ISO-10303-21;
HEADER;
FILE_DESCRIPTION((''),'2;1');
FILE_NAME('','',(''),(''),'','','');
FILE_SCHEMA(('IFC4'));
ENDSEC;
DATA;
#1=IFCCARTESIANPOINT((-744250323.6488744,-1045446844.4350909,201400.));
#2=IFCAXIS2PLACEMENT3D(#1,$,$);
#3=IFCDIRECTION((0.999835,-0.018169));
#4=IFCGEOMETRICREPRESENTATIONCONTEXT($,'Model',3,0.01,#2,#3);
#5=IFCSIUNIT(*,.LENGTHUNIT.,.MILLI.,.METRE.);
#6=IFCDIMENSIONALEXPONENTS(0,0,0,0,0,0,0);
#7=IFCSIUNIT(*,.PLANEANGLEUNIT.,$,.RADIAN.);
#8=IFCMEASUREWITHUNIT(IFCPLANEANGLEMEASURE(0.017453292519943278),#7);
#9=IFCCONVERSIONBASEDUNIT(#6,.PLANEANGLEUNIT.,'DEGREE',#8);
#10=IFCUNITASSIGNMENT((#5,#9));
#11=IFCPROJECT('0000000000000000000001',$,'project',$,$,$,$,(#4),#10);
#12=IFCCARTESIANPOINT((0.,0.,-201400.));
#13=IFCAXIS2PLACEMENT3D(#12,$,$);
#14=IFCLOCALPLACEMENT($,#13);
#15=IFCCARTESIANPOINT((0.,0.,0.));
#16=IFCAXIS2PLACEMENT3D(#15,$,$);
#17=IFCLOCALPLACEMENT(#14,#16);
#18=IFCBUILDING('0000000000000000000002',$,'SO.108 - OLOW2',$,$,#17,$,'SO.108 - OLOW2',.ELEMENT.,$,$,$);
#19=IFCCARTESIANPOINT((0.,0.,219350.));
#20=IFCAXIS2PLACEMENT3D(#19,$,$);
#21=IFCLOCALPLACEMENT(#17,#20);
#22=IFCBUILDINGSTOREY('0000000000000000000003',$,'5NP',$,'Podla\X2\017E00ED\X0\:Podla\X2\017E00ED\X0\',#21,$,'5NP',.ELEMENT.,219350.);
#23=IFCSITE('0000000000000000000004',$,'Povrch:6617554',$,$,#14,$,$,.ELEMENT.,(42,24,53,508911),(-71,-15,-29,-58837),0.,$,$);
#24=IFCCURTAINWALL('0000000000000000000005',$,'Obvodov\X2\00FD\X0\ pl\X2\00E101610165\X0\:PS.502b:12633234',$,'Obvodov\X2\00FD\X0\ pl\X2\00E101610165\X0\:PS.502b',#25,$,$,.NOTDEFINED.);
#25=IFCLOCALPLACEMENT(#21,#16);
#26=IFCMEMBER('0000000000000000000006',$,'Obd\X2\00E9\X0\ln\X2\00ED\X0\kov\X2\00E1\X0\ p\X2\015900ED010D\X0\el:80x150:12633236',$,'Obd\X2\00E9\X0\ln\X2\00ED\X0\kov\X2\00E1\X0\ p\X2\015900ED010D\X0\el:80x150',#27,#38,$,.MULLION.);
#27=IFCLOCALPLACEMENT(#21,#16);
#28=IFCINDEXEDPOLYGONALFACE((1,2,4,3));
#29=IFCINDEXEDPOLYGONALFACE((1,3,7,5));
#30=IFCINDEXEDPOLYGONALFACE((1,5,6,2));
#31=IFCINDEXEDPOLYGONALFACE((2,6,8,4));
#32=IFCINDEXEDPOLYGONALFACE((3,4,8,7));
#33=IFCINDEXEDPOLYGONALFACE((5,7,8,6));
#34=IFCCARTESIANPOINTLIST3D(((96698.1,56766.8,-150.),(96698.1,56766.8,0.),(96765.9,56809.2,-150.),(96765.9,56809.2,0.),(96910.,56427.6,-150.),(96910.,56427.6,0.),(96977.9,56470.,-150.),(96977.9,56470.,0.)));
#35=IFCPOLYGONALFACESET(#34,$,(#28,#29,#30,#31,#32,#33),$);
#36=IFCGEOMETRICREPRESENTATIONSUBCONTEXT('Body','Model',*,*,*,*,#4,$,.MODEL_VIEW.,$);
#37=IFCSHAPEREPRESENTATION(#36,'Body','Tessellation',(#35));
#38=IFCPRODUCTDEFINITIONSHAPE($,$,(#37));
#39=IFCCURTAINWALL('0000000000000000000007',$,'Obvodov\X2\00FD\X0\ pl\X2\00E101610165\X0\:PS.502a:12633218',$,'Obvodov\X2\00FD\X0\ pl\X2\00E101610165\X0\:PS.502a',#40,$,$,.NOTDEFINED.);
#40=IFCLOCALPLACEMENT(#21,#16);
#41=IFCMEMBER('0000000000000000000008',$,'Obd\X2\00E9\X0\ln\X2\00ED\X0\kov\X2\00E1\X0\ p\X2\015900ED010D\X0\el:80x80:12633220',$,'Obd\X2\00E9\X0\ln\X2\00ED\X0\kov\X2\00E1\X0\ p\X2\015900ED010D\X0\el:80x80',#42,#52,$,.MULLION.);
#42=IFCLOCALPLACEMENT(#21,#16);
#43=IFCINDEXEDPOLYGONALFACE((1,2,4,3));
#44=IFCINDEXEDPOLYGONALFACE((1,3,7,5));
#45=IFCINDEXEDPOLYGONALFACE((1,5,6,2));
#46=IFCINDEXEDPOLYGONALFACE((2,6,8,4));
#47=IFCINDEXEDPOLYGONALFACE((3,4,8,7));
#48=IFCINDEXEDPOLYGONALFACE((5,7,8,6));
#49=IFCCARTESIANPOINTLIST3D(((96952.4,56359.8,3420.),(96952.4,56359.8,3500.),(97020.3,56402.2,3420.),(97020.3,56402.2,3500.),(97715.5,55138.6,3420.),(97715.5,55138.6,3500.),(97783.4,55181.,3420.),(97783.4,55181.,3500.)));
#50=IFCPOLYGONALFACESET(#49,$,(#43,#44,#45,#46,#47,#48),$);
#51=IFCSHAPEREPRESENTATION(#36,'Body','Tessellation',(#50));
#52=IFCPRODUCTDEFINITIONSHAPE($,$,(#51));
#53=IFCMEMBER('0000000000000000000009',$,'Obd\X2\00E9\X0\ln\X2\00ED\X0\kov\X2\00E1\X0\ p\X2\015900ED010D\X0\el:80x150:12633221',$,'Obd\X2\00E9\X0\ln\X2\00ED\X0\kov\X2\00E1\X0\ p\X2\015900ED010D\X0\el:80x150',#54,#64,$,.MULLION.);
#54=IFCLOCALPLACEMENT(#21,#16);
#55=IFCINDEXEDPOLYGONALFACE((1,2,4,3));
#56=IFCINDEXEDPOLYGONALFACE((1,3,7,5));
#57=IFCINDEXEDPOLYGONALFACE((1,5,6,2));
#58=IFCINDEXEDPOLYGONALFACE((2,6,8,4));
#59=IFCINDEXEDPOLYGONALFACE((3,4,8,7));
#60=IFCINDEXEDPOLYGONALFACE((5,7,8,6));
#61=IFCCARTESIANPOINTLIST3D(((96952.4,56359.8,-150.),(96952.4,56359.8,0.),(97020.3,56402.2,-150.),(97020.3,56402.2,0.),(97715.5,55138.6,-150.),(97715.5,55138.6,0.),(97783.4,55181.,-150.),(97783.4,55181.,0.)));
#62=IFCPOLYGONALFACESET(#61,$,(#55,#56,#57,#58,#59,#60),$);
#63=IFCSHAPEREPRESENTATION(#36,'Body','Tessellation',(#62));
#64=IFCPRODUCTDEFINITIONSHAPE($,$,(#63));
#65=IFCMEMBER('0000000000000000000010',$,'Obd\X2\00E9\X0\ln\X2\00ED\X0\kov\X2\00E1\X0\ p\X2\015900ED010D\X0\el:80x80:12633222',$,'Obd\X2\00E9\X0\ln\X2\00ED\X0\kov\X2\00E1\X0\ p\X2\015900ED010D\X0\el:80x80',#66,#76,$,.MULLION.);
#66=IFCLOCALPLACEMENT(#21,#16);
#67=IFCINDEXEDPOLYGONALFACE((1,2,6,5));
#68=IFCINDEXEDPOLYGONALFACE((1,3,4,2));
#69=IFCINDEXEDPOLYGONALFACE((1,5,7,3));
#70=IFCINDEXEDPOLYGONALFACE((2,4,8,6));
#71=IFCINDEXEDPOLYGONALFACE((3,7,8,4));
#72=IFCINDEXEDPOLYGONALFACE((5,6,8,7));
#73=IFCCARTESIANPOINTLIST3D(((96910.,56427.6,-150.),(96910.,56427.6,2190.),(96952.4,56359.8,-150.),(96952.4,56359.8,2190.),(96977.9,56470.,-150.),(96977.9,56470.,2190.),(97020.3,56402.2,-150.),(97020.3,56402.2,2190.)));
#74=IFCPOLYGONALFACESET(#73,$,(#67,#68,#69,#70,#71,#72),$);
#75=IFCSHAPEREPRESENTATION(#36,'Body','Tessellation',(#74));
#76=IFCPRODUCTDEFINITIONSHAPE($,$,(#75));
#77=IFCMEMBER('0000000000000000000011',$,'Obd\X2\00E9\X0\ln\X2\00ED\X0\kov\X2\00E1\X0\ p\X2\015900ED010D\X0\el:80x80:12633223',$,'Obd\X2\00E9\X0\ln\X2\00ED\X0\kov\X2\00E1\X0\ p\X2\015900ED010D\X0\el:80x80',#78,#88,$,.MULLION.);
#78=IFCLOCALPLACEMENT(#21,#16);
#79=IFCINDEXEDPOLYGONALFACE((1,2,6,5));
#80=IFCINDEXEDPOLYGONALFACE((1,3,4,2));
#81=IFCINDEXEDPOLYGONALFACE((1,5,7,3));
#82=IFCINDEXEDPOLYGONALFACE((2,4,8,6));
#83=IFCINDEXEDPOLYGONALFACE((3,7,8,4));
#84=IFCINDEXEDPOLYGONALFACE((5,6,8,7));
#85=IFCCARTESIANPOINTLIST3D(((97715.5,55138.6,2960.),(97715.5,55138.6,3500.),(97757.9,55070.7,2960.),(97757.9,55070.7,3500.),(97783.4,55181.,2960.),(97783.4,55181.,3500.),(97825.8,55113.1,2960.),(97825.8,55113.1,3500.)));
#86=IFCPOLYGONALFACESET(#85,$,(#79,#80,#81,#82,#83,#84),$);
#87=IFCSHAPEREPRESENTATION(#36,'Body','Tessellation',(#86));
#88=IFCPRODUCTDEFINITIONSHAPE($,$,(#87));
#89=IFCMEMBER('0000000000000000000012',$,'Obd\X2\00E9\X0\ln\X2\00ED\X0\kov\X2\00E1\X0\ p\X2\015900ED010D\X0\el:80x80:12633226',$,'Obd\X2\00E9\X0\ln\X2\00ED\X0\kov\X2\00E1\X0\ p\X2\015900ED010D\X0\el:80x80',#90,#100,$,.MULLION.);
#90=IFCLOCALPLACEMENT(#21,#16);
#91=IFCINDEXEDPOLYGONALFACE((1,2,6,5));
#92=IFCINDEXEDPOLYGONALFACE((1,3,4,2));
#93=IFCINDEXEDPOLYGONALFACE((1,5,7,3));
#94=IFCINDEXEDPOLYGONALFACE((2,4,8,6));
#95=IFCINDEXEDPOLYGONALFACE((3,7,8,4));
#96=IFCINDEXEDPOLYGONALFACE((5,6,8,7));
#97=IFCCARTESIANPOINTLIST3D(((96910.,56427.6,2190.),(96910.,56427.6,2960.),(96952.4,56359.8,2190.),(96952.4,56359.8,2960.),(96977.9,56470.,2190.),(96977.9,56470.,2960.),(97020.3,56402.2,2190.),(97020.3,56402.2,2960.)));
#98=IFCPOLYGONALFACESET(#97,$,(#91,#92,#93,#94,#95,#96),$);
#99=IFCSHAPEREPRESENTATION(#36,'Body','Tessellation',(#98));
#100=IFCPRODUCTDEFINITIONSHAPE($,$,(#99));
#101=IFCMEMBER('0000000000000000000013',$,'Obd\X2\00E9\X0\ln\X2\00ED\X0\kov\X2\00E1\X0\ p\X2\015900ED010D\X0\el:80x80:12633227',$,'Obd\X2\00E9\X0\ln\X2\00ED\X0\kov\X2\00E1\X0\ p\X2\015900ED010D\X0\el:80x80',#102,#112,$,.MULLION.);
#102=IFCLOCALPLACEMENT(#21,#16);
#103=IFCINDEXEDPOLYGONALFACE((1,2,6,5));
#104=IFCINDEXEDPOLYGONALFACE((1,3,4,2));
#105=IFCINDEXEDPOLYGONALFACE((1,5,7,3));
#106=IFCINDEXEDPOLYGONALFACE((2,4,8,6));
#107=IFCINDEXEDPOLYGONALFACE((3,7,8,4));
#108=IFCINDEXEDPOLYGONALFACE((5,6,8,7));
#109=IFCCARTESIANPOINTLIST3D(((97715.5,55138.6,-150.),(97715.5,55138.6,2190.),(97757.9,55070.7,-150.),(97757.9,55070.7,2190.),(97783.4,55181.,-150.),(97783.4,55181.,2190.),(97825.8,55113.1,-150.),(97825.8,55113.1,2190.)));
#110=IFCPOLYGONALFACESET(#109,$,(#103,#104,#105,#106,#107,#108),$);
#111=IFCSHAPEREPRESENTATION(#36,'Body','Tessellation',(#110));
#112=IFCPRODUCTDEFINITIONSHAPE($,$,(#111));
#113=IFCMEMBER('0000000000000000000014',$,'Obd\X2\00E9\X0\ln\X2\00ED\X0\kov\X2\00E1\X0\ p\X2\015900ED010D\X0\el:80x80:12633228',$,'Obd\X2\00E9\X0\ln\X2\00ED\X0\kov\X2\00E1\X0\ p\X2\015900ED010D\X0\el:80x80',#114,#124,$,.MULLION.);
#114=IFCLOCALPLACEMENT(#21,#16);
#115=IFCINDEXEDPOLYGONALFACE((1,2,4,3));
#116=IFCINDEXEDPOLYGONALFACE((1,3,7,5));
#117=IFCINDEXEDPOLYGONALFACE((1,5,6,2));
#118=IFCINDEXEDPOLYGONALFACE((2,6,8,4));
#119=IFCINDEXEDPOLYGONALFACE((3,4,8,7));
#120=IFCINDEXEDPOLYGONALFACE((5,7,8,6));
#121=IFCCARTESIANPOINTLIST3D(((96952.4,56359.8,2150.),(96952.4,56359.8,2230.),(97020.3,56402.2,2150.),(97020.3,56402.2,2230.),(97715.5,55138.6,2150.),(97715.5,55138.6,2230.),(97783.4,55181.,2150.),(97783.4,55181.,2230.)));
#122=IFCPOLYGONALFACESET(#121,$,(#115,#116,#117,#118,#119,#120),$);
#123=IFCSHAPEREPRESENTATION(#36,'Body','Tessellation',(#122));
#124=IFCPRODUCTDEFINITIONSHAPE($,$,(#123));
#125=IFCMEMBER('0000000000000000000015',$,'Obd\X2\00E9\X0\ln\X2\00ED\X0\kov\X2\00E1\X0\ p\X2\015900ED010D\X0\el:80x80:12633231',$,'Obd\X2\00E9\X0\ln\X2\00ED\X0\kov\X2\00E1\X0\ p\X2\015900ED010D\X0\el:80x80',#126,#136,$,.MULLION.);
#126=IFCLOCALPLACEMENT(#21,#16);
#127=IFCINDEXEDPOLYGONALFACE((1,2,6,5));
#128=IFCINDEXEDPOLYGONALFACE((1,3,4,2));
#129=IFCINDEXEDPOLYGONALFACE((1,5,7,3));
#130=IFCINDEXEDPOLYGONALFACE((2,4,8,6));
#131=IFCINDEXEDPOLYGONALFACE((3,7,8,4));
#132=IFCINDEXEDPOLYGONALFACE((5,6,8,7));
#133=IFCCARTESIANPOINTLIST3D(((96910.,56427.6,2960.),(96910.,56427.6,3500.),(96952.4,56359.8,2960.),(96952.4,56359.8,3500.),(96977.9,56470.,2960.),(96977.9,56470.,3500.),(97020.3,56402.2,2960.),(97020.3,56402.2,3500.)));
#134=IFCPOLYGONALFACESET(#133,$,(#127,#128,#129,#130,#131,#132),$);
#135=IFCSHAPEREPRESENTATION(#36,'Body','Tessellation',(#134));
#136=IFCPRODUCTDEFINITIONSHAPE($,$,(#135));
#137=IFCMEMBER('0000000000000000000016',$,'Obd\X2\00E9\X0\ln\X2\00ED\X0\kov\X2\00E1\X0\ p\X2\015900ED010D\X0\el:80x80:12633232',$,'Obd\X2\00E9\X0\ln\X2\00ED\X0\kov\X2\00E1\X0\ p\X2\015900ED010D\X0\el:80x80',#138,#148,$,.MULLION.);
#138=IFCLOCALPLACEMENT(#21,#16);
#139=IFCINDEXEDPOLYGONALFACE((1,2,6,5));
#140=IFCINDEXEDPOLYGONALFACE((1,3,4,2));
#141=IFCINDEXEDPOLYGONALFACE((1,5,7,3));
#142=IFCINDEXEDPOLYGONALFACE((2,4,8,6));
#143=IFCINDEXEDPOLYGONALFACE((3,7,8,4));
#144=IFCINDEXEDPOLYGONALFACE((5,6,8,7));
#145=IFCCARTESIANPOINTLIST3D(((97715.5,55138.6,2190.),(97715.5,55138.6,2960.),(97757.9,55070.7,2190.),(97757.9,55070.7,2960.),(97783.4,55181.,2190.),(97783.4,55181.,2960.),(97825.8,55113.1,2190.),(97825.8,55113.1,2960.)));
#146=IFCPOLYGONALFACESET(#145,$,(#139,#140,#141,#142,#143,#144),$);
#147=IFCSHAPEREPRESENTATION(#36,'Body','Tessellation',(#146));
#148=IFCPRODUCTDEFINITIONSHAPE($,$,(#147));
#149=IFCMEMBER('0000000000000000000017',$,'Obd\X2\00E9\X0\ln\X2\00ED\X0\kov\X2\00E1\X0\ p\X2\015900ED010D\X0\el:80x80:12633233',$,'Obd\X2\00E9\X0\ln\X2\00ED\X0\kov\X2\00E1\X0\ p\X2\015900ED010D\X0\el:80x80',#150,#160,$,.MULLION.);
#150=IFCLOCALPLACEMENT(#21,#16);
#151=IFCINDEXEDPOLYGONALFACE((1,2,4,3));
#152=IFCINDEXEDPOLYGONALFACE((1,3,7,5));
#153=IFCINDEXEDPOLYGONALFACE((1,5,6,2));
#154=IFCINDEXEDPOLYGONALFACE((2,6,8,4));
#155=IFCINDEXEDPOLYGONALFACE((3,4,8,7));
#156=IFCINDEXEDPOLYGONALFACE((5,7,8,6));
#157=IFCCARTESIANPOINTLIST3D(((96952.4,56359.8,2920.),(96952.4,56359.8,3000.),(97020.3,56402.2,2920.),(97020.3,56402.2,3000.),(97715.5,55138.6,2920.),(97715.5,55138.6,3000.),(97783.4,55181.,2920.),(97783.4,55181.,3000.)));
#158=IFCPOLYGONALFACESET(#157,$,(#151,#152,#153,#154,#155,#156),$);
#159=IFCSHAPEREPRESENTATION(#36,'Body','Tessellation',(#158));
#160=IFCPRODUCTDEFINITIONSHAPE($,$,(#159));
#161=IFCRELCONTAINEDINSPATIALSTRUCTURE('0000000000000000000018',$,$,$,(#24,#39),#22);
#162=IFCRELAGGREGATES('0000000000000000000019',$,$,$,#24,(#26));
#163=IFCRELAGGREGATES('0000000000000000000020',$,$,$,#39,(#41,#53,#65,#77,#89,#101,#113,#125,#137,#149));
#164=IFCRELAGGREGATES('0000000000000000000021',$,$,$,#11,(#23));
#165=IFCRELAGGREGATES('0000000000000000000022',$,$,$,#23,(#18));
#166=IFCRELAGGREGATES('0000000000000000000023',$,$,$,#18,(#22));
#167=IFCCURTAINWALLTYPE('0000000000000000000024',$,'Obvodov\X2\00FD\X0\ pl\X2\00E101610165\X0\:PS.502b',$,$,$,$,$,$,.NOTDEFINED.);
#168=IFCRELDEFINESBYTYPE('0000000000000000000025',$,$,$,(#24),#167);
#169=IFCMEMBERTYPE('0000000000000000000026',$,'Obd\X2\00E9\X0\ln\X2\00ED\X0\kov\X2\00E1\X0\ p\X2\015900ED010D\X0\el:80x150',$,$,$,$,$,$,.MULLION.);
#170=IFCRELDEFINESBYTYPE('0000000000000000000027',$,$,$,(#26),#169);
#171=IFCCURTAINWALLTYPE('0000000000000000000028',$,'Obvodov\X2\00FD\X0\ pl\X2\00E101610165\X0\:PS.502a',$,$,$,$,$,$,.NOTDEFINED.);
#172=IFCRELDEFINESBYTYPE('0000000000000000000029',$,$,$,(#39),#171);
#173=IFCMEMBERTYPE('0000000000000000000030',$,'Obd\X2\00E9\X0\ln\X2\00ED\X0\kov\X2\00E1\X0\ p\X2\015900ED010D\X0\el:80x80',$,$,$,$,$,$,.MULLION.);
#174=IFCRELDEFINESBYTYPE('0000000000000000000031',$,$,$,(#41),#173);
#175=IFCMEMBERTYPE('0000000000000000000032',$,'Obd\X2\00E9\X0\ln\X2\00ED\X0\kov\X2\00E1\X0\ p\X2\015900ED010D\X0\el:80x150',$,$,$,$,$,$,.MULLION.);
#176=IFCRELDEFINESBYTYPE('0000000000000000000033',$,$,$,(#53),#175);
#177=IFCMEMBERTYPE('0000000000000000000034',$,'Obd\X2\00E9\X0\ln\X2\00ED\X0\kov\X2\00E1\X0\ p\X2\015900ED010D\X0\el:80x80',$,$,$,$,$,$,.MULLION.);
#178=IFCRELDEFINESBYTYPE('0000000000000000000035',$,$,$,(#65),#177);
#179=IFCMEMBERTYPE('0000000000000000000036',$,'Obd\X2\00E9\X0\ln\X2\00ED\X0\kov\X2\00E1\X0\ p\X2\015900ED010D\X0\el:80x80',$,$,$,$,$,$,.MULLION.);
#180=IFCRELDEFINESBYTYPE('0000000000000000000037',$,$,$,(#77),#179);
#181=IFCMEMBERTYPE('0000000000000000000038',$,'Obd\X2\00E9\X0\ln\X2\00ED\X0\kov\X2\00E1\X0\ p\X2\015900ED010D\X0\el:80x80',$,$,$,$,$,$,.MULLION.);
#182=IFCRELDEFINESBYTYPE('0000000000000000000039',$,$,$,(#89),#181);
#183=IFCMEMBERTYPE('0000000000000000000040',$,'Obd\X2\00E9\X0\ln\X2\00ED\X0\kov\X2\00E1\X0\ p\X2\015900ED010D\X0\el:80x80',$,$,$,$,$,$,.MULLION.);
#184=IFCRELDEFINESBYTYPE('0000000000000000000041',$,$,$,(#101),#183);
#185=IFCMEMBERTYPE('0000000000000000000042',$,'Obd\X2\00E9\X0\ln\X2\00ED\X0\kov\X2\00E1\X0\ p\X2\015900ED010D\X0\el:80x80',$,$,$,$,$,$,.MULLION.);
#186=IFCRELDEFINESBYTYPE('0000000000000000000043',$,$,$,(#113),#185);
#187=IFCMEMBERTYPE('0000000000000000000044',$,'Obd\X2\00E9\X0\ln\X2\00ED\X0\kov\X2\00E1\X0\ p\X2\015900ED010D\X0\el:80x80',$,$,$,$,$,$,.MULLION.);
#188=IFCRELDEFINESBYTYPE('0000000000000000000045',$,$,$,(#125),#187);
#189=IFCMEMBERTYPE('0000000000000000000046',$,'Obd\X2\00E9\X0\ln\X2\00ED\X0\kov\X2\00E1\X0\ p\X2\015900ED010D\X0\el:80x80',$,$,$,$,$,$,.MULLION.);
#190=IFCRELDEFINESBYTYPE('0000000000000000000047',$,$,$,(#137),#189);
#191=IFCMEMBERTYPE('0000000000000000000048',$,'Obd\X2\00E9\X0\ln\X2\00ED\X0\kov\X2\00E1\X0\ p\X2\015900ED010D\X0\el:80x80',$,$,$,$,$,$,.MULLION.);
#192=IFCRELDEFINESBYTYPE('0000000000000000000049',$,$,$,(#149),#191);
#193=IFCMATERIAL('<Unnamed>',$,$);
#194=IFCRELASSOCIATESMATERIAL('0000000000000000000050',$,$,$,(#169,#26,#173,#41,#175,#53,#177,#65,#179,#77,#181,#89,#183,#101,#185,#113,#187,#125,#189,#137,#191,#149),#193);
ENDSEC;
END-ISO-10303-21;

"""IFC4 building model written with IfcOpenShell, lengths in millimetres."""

from ifc_helpers import new_model, entity, si_unit, converted_unit, direction, frame, origin, place, context, subcontext, project, spatial, indexed_curve, outline, extrude, source, transform, mapped, material, type_object, type_shapes, element, aggregate, save


model = new_model("IFC4")

# Units and contexts
model_context = context("Model", 3, precision=0.01, world=frame((-744250323.6488744, -1045446844.4350909, 201400.0)), true_north=direction((0.999835, -0.018169)))
body_context = subcontext(model_context, "Body", "Model", "MODEL_VIEW")
ifc_project = project(units=[si_unit("LENGTHUNIT", "METRE", prefix="MILLI"), converted_unit("PLANEANGLEUNIT", "DEGREE", entity("IfcPlaneAngleMeasure", 0.017453292519943278), si_unit("PLANEANGLEUNIT", "RADIAN"), dimensions=[0, 0, 0, 0, 0, 0, 0])], contexts=[model_context])

# Site, building, storey
site_placement = place(None, frame((0.0, 0.0, -201400.0)))
site = spatial("IfcSite", under=ifc_project, at=site_placement, Name="Povrch:6617554", CompositionType="ELEMENT", RefLatitude=(42, 24, 53, 508911), RefLongitude=(-71, -15, -29, -58837), RefElevation=0.0)
building_placement = place(site_placement, origin())
building = spatial("IfcBuilding", under=site, at=building_placement, Name="SO.108 - OLOW2", LongName="SO.108 - OLOW2", CompositionType="ELEMENT")
storey_placement = place(building_placement, frame((0.0, 0.0, 219350.0)))
storey = spatial("IfcBuildingStorey", under=building, at=storey_placement, Name="5NP", ObjectType="Podlaží:Podlaží", LongName="5NP", CompositionType="ELEMENT", Elevation=219350.0)

# Shared definitions
ifc_material_1 = material(Name="<Unnamed>")

# Curtain wall, member
curtain_wall_type_1 = type_object("IfcCurtainWallType", Name="Obvodový plášť:PS.502b", PredefinedType="NOTDEFINED")
curtain_wall_1_placement = place(storey_placement, frame((0.0, 0.0, -219350.0)))
curtain_wall_1 = element("IfcCurtainWall", 1, at=curtain_wall_1_placement, inside=storey, type_object=curtain_wall_type_1, Name="Obvodový plášť:PS.502b:12633234", ObjectType="Obvodový plášť:PS.502b", PredefinedType="NOTDEFINED")
member_type_1 = type_object("IfcMemberType", Name="Obdélníková příčel:80x150", PredefinedType="MULLION", material=ifc_material_1)
shared_shape_1 = source(origin(), body_context, "Body", "SweptSolid", [
    extrude(outline(indexed_curve([(-75.0, -40.0), (75.0, -40.0), (75.0, 40.0), (-75.0, 40.0), (-75.0, -40.0)], self_intersect=False)), frame((-75.0, 0.0, -400.0), z_axis=(0.0, 0.0, 1.0), x_axis=(-1.0, 0.0, 0.0)), (0.0, 0.0, 1.0), 400.0),
])
type_shapes(member_type_1, [shared_shape_1])
member_1_placement = place(curtain_wall_1_placement, frame((96732.0, 56788.0, 219200.0), z_axis=(-0.529919, 0.848048, 0.0), x_axis=(0.0, 0.0, -1.0)))
member_1 = element("IfcMember", 2, at=member_1_placement, type_object=member_type_1, material=ifc_material_1, Name="Obdélníková příčel:80x150:12633236", ObjectType="Obdélníková příčel:80x150", PredefinedType="MULLION", context=body_context, shape_type="MappedRepresentation", body=[
    mapped(shared_shape_1, transform((0.0, 0.0, 0.0), scale=1.0)),
])

# Curtain wall, members
curtain_wall_type_2 = type_object("IfcCurtainWallType", Name="Obvodový plášť:PS.502a", PredefinedType="NOTDEFINED")
curtain_wall_2_placement = place(storey_placement, frame((0.0, 0.0, -219350.0)))
curtain_wall_2 = element("IfcCurtainWall", 3, at=curtain_wall_2_placement, inside=storey, type_object=curtain_wall_type_2, Name="Obvodový plášť:PS.502a:12633218", ObjectType="Obvodový plášť:PS.502a", PredefinedType="NOTDEFINED")
member_type_2 = type_object("IfcMemberType", Name="Obdélníková příčel:80x80", PredefinedType="MULLION", material=ifc_material_1)
shared_shape_2 = source(origin(), body_context, "Body", "SweptSolid", [
    extrude(outline(indexed_curve([(-40.0, -40.0), (40.0, -40.0), (40.0, 40.0), (-40.0, 40.0), (-40.0, -40.0)], self_intersect=False)), frame((-40.0, 0.0, -1440.0), z_axis=(0.0, 0.0, 1.0), x_axis=(-1.0, 0.0, 0.0)), (0.0, 0.0, 1.0), 1440.0),
])
type_shapes(member_type_2, [shared_shape_2])
member_2_placement = place(curtain_wall_2_placement, frame((96986.4, 56381.0, 222850.0), z_axis=(-0.529919, 0.848048, 0.0), x_axis=(0.0, 0.0, 1.0)))
member_2 = element("IfcMember", 4, at=member_2_placement, type_object=member_type_2, material=ifc_material_1, Name="Obdélníková příčel:80x80:12633220", ObjectType="Obdélníková příčel:80x80", PredefinedType="MULLION", context=body_context, shape_type="MappedRepresentation", body=[
    mapped(shared_shape_2, transform((0.0, 0.0, 0.0), scale=1.0)),
])
member_type_3 = type_object("IfcMemberType", Name="Obdélníková příčel:80x150", PredefinedType="MULLION", material=ifc_material_1)
shared_shape_3 = source(origin(), body_context, "Body", "SweptSolid", [
    extrude(outline(indexed_curve([(-75.0, -40.0), (75.0, -40.0), (75.0, 40.0), (-75.0, 40.0), (-75.0, -40.0)], self_intersect=False)), frame((-75.0, 0.0, -1440.0), z_axis=(0.0, 0.0, 1.0), x_axis=(-1.0, 0.0, 0.0)), (0.0, 0.0, 1.0), 1440.0),
])
type_shapes(member_type_3, [shared_shape_3])
member_3_placement = place(curtain_wall_2_placement, frame((97749.4, 55159.8, 219200.0), z_axis=(0.529919, -0.848048, 0.0), x_axis=(0.0, 0.0, -1.0)))
member_3 = element("IfcMember", 5, at=member_3_placement, type_object=member_type_3, material=ifc_material_1, Name="Obdélníková příčel:80x150:12633221", ObjectType="Obdélníková příčel:80x150", PredefinedType="MULLION", context=body_context, shape_type="MappedRepresentation", body=[
    mapped(shared_shape_3, transform((0.0, 0.0, 0.0), scale=1.0)),
])
member_type_4 = type_object("IfcMemberType", Name="Obdélníková příčel:80x80", PredefinedType="MULLION", material=ifc_material_1)
shared_shape_4 = source(origin(), body_context, "Body", "SweptSolid", [
    extrude(outline(indexed_curve([(-40.0, -40.0), (40.0, -40.0), (40.0, 40.0), (-40.0, 40.0), (-40.0, -40.0)], self_intersect=False)), frame((-40.0, 0.0, -2340.0), z_axis=(0.0, 0.0, 1.0), x_axis=(-1.0, 0.0, 0.0)), (0.0, 0.0, 1.0), 2340.0),
])
type_shapes(member_type_4, [shared_shape_4])
member_4_placement = place(curtain_wall_2_placement, frame((96944.0, 56448.8, 219200.0), z_axis=(0.0, 0.0, -1.0), x_axis=(-0.529919, 0.848048, 0.0)))
member_4 = element("IfcMember", 6, at=member_4_placement, type_object=member_type_4, material=ifc_material_1, Name="Obdélníková příčel:80x80:12633222", ObjectType="Obdélníková příčel:80x80", PredefinedType="MULLION", context=body_context, shape_type="MappedRepresentation", body=[
    mapped(shared_shape_4, transform((0.0, 0.0, 0.0), scale=1.0)),
])
member_type_5 = type_object("IfcMemberType", Name="Obdélníková příčel:80x80", PredefinedType="MULLION", material=ifc_material_1)
shared_shape_5 = source(origin(), body_context, "Body", "SweptSolid", [
    extrude(outline(indexed_curve([(-40.0, -40.0), (40.0, -40.0), (40.0, 40.0), (-40.0, 40.0), (-40.0, -40.0)], self_intersect=False)), frame((-40.0, 0.0, -540.0), z_axis=(0.0, 0.0, 1.0), x_axis=(-1.0, 0.0, 0.0)), (0.0, 0.0, 1.0), 540.0),
])
type_shapes(member_type_5, [shared_shape_5])
member_5_placement = place(curtain_wall_2_placement, frame((97791.8, 55091.9, 222850.0), z_axis=(0.0, 0.0, 1.0), x_axis=(0.529919, -0.848048, 0.0)))
member_5 = element("IfcMember", 7, at=member_5_placement, type_object=member_type_5, material=ifc_material_1, Name="Obdélníková příčel:80x80:12633223", ObjectType="Obdélníková příčel:80x80", PredefinedType="MULLION", context=body_context, shape_type="MappedRepresentation", body=[
    mapped(shared_shape_5, transform((0.0, 0.0, 0.0), scale=1.0)),
])
member_type_6 = type_object("IfcMemberType", Name="Obdélníková příčel:80x80", PredefinedType="MULLION", material=ifc_material_1)
shared_shape_6 = source(origin(), body_context, "Body", "SweptSolid", [
    extrude(outline(indexed_curve([(-40.0, -40.0), (40.0, -40.0), (40.0, 40.0), (-40.0, 40.0), (-40.0, -40.0)], self_intersect=False)), frame((-40.0, 0.0, -770.0), z_axis=(0.0, 0.0, 1.0), x_axis=(-1.0, 0.0, 0.0)), (0.0, 0.0, 1.0), 770.0),
])
type_shapes(member_type_6, [shared_shape_6])
member_6_placement = place(curtain_wall_2_placement, frame((96944.0, 56448.8, 221540.0), z_axis=(0.0, 0.0, -1.0), x_axis=(-0.529919, 0.848048, 0.0)))
member_6 = element("IfcMember", 8, at=member_6_placement, type_object=member_type_6, material=ifc_material_1, Name="Obdélníková příčel:80x80:12633226", ObjectType="Obdélníková příčel:80x80", PredefinedType="MULLION", context=body_context, shape_type="MappedRepresentation", body=[
    mapped(shared_shape_6, transform((0.0, 0.0, 0.0), scale=1.0)),
])
member_type_7 = type_object("IfcMemberType", Name="Obdélníková příčel:80x80", PredefinedType="MULLION", material=ifc_material_1)
shared_shape_7 = source(origin(), body_context, "Body", "SweptSolid", [
    extrude(outline(indexed_curve([(-40.0, -40.0), (40.0, -40.0), (40.0, 40.0), (-40.0, 40.0), (-40.0, -40.0)], self_intersect=False)), frame((-40.0, 0.0, -2340.0), z_axis=(0.0, 0.0, 1.0), x_axis=(-1.0, 0.0, 0.0)), (0.0, 0.0, 1.0), 2340.0),
])
type_shapes(member_type_7, [shared_shape_7])
member_7_placement = place(curtain_wall_2_placement, frame((97791.8, 55091.9, 221540.0), z_axis=(0.0, 0.0, 1.0), x_axis=(0.529919, -0.848048, 0.0)))
member_7 = element("IfcMember", 9, at=member_7_placement, type_object=member_type_7, material=ifc_material_1, Name="Obdélníková příčel:80x80:12633227", ObjectType="Obdélníková příčel:80x80", PredefinedType="MULLION", context=body_context, shape_type="MappedRepresentation", body=[
    mapped(shared_shape_7, transform((0.0, 0.0, 0.0), scale=1.0)),
])
member_type_8 = type_object("IfcMemberType", Name="Obdélníková příčel:80x80", PredefinedType="MULLION", material=ifc_material_1)
shared_shape_8 = source(origin(), body_context, "Body", "SweptSolid", [
    extrude(outline(indexed_curve([(-40.0, -40.0), (40.0, -40.0), (40.0, 40.0), (-40.0, 40.0), (-40.0, -40.0)], self_intersect=False)), frame((0.0, 0.0, -1440.0), z_axis=(0.0, 0.0, 1.0), x_axis=(-1.0, 0.0, 0.0)), (0.0, 0.0, 1.0), 1440.0),
])
type_shapes(member_type_8, [shared_shape_8])
member_8_placement = place(curtain_wall_2_placement, frame((96986.4, 56381.0, 221540.0), z_axis=(-0.529919, 0.848048, 0.0), x_axis=(0.0, 0.0, 1.0)))
member_8 = element("IfcMember", 10, at=member_8_placement, type_object=member_type_8, material=ifc_material_1, Name="Obdélníková příčel:80x80:12633228", ObjectType="Obdélníková příčel:80x80", PredefinedType="MULLION", context=body_context, shape_type="MappedRepresentation", body=[
    mapped(shared_shape_8, transform((0.0, 0.0, 0.0), scale=1.0)),
])
member_type_9 = type_object("IfcMemberType", Name="Obdélníková příčel:80x80", PredefinedType="MULLION", material=ifc_material_1)
shared_shape_9 = source(origin(), body_context, "Body", "SweptSolid", [
    extrude(outline(indexed_curve([(-40.0, -40.0), (40.0, -40.0), (40.0, 40.0), (-40.0, 40.0), (-40.0, -40.0)], self_intersect=False)), frame((-40.0, 0.0, -540.0), z_axis=(0.0, 0.0, 1.0), x_axis=(-1.0, 0.0, 0.0)), (0.0, 0.0, 1.0), 540.0),
])
type_shapes(member_type_9, [shared_shape_9])
member_9_placement = place(curtain_wall_2_placement, frame((96944.0, 56448.8, 222310.0), z_axis=(0.0, 0.0, -1.0), x_axis=(-0.529919, 0.848048, 0.0)))
member_9 = element("IfcMember", 11, at=member_9_placement, type_object=member_type_9, material=ifc_material_1, Name="Obdélníková příčel:80x80:12633231", ObjectType="Obdélníková příčel:80x80", PredefinedType="MULLION", context=body_context, shape_type="MappedRepresentation", body=[
    mapped(shared_shape_9, transform((0.0, 0.0, 0.0), scale=1.0)),
])
member_type_10 = type_object("IfcMemberType", Name="Obdélníková příčel:80x80", PredefinedType="MULLION", material=ifc_material_1)
shared_shape_10 = source(origin(), body_context, "Body", "SweptSolid", [
    extrude(outline(indexed_curve([(-40.0, -40.0), (40.0, -40.0), (40.0, 40.0), (-40.0, 40.0), (-40.0, -40.0)], self_intersect=False)), frame((-40.0, 0.0, -770.0), z_axis=(0.0, 0.0, 1.0), x_axis=(-1.0, 0.0, 0.0)), (0.0, 0.0, 1.0), 770.0),
])
type_shapes(member_type_10, [shared_shape_10])
member_10_placement = place(curtain_wall_2_placement, frame((97791.8, 55091.9, 222310.0), z_axis=(0.0, 0.0, 1.0), x_axis=(0.529919, -0.848048, 0.0)))
member_10 = element("IfcMember", 12, at=member_10_placement, type_object=member_type_10, material=ifc_material_1, Name="Obdélníková příčel:80x80:12633232", ObjectType="Obdélníková příčel:80x80", PredefinedType="MULLION", context=body_context, shape_type="MappedRepresentation", body=[
    mapped(shared_shape_10, transform((0.0, 0.0, 0.0), scale=1.0)),
])
member_type_11 = type_object("IfcMemberType", Name="Obdélníková příčel:80x80", PredefinedType="MULLION", material=ifc_material_1)
shared_shape_11 = source(origin(), body_context, "Body", "SweptSolid", [
    extrude(outline(indexed_curve([(-40.0, -40.0), (40.0, -40.0), (40.0, 40.0), (-40.0, 40.0), (-40.0, -40.0)], self_intersect=False)), frame((0.0, 0.0, -1440.0), z_axis=(0.0, 0.0, 1.0), x_axis=(-1.0, 0.0, 0.0)), (0.0, 0.0, 1.0), 1440.0),
])
type_shapes(member_type_11, [shared_shape_11])
member_11_placement = place(curtain_wall_2_placement, frame((96986.4, 56381.0, 222310.0), z_axis=(-0.529919, 0.848048, 0.0), x_axis=(0.0, 0.0, 1.0)))
member_11 = element("IfcMember", 13, at=member_11_placement, type_object=member_type_11, material=ifc_material_1, Name="Obdélníková příčel:80x80:12633233", ObjectType="Obdélníková příčel:80x80", PredefinedType="MULLION", context=body_context, shape_type="MappedRepresentation", body=[
    mapped(shared_shape_11, transform((0.0, 0.0, 0.0), scale=1.0)),
])

aggregate(curtain_wall_1, [member_1])

aggregate(curtain_wall_2, [member_2, member_3, member_4, member_5, member_6, member_7, member_8, member_9, member_10, member_11])

save(model, "model.ifc")
